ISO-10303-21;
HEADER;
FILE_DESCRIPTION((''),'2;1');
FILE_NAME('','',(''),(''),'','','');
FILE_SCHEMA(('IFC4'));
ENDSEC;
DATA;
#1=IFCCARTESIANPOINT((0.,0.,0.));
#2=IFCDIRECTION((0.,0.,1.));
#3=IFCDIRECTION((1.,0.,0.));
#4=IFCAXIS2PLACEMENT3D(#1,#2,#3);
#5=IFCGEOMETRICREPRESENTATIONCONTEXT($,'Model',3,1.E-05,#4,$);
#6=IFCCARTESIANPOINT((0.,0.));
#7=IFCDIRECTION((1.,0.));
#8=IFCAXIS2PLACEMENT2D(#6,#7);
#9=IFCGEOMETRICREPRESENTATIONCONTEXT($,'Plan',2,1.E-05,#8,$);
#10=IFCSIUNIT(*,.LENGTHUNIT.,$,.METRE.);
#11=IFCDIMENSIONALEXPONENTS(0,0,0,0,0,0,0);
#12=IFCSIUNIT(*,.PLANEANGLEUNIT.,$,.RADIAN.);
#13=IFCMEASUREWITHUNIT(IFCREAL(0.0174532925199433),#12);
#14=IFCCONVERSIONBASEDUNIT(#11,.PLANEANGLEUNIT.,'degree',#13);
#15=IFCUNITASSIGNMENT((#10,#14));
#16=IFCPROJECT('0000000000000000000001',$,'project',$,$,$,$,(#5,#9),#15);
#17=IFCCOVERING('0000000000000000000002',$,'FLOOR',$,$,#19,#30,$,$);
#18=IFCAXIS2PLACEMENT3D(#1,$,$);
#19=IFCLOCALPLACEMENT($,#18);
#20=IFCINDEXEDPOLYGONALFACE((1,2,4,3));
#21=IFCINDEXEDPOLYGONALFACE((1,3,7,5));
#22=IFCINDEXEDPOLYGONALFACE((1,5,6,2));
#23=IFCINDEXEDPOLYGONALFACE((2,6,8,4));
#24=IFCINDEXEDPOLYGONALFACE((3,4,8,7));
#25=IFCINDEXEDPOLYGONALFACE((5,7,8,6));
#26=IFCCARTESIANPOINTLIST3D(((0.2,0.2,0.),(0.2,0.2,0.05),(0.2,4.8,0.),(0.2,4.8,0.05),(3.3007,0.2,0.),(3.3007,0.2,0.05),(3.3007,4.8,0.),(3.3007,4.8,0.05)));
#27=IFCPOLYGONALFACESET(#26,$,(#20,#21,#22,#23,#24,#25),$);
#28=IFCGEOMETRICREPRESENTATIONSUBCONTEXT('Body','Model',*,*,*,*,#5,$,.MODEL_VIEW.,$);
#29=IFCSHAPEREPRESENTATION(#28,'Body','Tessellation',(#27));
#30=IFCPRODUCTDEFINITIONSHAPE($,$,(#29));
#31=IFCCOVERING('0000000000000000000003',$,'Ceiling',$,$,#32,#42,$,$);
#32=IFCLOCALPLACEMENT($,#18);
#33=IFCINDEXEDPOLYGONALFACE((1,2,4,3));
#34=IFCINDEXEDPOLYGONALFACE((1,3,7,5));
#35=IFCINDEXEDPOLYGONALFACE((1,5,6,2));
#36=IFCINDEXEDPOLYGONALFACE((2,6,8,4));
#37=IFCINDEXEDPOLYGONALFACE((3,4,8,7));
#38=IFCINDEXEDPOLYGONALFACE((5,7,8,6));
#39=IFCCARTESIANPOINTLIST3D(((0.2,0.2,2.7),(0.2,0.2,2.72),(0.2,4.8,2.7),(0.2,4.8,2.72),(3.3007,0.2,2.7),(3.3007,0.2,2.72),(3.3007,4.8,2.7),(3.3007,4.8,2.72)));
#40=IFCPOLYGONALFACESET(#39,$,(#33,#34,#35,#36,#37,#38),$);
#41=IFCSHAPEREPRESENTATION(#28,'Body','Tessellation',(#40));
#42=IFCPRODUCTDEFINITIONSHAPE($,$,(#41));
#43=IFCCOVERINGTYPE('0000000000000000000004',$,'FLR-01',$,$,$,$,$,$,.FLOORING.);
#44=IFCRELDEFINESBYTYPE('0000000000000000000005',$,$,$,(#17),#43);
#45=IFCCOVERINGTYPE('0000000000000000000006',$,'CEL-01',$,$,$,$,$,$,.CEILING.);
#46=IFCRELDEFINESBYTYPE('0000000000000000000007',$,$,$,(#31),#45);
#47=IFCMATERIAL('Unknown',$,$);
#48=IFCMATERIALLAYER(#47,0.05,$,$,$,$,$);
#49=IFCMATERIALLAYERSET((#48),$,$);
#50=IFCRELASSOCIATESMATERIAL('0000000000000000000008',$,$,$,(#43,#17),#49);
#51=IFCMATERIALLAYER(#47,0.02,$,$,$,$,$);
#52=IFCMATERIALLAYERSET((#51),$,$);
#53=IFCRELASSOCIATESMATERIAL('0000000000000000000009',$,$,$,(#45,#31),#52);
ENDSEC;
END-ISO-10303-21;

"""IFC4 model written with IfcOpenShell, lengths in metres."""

from ifc_helpers import new_model, entity, si_unit, converted_unit, frame, origin_with_axes, origin_2d_with_axis, place, context, subcontext, project, line, indexed_curve, outline, extrude, material, layer, layer_set, layer_usage, type_object, element, save


model = new_model("IFC4")

# Units and contexts
model_context = context("Model", 3, precision=1e-05, world=origin_with_axes())
plan_context = context("Plan", 2, precision=1e-05, world=origin_2d_with_axis())
body_context = subcontext(model_context, "Body", "Model", "MODEL_VIEW")
ifc_project = project(units=[si_unit("LENGTHUNIT", "METRE"), converted_unit("PLANEANGLEUNIT", "degree", entity("IfcReal", 0.0174532925199433), si_unit("PLANEANGLEUNIT", "RADIAN"), dimensions=[0, 0, 0, 0, 0, 0, 0])], contexts=[model_context, plan_context])

# Coverings
ifc_material = material(Name="Unknown")
ifc_layer_1 = layer(ifc_material, 0.05)
ifc_layer_set_1 = layer_set([ifc_layer_1])
ifc_layer_usage_1 = layer_usage(ifc_layer_set_1, "AXIS3", "POSITIVE", 0.0)
covering_type_1 = type_object("IfcCoveringType", Name="FLR-01", PredefinedType="FLOORING", material=ifc_layer_set_1)
covering_1_placement = place(None, frame((0.2, 0.2, 0.0), z_axis=(0.0, 0.0, 1.0), x_axis=(1.0, 0.0, 0.0)))
element("IfcCovering", 1, at=covering_1_placement, type_object=covering_type_1, material=ifc_layer_usage_1, Name="FLOOR", context=body_context, shape_type="SweptSolid", body=[
    extrude(outline(indexed_curve([(0.0, 0.0), (3.1007, 0.0), (3.1007, 4.6), (0.0, 4.6)], segments=[line(3, 2), line(2, 1), line(1, 4), line(4, 3)], self_intersect=False)), None, (0.0, 0.0, 1.0), 0.05),
])
ifc_layer_2 = layer(ifc_material, 0.02)
ifc_layer_set_2 = layer_set([ifc_layer_2])
ifc_layer_usage_2 = layer_usage(ifc_layer_set_2, "AXIS3", "POSITIVE", 0.0)
covering_type_2 = type_object("IfcCoveringType", Name="CEL-01", PredefinedType="CEILING", material=ifc_layer_set_2)
covering_2_placement = place(None, frame((0.2, 0.2, 2.7), z_axis=(0.0, 0.0, 1.0), x_axis=(1.0, 0.0, 0.0)))
element("IfcCovering", 2, at=covering_2_placement, type_object=covering_type_2, material=ifc_layer_usage_2, Name="Ceiling", context=body_context, shape_type="SweptSolid", body=[
    extrude(outline(indexed_curve([(0.0, 0.0), (3.1007, 0.0), (3.1007, 4.6), (0.0, 4.6)], segments=[line(4, 1), line(1, 2), line(2, 3), line(3, 4)], self_intersect=False)), None, (0.0, 0.0, 1.0), 0.02),
])

save(model, "model.ifc")
